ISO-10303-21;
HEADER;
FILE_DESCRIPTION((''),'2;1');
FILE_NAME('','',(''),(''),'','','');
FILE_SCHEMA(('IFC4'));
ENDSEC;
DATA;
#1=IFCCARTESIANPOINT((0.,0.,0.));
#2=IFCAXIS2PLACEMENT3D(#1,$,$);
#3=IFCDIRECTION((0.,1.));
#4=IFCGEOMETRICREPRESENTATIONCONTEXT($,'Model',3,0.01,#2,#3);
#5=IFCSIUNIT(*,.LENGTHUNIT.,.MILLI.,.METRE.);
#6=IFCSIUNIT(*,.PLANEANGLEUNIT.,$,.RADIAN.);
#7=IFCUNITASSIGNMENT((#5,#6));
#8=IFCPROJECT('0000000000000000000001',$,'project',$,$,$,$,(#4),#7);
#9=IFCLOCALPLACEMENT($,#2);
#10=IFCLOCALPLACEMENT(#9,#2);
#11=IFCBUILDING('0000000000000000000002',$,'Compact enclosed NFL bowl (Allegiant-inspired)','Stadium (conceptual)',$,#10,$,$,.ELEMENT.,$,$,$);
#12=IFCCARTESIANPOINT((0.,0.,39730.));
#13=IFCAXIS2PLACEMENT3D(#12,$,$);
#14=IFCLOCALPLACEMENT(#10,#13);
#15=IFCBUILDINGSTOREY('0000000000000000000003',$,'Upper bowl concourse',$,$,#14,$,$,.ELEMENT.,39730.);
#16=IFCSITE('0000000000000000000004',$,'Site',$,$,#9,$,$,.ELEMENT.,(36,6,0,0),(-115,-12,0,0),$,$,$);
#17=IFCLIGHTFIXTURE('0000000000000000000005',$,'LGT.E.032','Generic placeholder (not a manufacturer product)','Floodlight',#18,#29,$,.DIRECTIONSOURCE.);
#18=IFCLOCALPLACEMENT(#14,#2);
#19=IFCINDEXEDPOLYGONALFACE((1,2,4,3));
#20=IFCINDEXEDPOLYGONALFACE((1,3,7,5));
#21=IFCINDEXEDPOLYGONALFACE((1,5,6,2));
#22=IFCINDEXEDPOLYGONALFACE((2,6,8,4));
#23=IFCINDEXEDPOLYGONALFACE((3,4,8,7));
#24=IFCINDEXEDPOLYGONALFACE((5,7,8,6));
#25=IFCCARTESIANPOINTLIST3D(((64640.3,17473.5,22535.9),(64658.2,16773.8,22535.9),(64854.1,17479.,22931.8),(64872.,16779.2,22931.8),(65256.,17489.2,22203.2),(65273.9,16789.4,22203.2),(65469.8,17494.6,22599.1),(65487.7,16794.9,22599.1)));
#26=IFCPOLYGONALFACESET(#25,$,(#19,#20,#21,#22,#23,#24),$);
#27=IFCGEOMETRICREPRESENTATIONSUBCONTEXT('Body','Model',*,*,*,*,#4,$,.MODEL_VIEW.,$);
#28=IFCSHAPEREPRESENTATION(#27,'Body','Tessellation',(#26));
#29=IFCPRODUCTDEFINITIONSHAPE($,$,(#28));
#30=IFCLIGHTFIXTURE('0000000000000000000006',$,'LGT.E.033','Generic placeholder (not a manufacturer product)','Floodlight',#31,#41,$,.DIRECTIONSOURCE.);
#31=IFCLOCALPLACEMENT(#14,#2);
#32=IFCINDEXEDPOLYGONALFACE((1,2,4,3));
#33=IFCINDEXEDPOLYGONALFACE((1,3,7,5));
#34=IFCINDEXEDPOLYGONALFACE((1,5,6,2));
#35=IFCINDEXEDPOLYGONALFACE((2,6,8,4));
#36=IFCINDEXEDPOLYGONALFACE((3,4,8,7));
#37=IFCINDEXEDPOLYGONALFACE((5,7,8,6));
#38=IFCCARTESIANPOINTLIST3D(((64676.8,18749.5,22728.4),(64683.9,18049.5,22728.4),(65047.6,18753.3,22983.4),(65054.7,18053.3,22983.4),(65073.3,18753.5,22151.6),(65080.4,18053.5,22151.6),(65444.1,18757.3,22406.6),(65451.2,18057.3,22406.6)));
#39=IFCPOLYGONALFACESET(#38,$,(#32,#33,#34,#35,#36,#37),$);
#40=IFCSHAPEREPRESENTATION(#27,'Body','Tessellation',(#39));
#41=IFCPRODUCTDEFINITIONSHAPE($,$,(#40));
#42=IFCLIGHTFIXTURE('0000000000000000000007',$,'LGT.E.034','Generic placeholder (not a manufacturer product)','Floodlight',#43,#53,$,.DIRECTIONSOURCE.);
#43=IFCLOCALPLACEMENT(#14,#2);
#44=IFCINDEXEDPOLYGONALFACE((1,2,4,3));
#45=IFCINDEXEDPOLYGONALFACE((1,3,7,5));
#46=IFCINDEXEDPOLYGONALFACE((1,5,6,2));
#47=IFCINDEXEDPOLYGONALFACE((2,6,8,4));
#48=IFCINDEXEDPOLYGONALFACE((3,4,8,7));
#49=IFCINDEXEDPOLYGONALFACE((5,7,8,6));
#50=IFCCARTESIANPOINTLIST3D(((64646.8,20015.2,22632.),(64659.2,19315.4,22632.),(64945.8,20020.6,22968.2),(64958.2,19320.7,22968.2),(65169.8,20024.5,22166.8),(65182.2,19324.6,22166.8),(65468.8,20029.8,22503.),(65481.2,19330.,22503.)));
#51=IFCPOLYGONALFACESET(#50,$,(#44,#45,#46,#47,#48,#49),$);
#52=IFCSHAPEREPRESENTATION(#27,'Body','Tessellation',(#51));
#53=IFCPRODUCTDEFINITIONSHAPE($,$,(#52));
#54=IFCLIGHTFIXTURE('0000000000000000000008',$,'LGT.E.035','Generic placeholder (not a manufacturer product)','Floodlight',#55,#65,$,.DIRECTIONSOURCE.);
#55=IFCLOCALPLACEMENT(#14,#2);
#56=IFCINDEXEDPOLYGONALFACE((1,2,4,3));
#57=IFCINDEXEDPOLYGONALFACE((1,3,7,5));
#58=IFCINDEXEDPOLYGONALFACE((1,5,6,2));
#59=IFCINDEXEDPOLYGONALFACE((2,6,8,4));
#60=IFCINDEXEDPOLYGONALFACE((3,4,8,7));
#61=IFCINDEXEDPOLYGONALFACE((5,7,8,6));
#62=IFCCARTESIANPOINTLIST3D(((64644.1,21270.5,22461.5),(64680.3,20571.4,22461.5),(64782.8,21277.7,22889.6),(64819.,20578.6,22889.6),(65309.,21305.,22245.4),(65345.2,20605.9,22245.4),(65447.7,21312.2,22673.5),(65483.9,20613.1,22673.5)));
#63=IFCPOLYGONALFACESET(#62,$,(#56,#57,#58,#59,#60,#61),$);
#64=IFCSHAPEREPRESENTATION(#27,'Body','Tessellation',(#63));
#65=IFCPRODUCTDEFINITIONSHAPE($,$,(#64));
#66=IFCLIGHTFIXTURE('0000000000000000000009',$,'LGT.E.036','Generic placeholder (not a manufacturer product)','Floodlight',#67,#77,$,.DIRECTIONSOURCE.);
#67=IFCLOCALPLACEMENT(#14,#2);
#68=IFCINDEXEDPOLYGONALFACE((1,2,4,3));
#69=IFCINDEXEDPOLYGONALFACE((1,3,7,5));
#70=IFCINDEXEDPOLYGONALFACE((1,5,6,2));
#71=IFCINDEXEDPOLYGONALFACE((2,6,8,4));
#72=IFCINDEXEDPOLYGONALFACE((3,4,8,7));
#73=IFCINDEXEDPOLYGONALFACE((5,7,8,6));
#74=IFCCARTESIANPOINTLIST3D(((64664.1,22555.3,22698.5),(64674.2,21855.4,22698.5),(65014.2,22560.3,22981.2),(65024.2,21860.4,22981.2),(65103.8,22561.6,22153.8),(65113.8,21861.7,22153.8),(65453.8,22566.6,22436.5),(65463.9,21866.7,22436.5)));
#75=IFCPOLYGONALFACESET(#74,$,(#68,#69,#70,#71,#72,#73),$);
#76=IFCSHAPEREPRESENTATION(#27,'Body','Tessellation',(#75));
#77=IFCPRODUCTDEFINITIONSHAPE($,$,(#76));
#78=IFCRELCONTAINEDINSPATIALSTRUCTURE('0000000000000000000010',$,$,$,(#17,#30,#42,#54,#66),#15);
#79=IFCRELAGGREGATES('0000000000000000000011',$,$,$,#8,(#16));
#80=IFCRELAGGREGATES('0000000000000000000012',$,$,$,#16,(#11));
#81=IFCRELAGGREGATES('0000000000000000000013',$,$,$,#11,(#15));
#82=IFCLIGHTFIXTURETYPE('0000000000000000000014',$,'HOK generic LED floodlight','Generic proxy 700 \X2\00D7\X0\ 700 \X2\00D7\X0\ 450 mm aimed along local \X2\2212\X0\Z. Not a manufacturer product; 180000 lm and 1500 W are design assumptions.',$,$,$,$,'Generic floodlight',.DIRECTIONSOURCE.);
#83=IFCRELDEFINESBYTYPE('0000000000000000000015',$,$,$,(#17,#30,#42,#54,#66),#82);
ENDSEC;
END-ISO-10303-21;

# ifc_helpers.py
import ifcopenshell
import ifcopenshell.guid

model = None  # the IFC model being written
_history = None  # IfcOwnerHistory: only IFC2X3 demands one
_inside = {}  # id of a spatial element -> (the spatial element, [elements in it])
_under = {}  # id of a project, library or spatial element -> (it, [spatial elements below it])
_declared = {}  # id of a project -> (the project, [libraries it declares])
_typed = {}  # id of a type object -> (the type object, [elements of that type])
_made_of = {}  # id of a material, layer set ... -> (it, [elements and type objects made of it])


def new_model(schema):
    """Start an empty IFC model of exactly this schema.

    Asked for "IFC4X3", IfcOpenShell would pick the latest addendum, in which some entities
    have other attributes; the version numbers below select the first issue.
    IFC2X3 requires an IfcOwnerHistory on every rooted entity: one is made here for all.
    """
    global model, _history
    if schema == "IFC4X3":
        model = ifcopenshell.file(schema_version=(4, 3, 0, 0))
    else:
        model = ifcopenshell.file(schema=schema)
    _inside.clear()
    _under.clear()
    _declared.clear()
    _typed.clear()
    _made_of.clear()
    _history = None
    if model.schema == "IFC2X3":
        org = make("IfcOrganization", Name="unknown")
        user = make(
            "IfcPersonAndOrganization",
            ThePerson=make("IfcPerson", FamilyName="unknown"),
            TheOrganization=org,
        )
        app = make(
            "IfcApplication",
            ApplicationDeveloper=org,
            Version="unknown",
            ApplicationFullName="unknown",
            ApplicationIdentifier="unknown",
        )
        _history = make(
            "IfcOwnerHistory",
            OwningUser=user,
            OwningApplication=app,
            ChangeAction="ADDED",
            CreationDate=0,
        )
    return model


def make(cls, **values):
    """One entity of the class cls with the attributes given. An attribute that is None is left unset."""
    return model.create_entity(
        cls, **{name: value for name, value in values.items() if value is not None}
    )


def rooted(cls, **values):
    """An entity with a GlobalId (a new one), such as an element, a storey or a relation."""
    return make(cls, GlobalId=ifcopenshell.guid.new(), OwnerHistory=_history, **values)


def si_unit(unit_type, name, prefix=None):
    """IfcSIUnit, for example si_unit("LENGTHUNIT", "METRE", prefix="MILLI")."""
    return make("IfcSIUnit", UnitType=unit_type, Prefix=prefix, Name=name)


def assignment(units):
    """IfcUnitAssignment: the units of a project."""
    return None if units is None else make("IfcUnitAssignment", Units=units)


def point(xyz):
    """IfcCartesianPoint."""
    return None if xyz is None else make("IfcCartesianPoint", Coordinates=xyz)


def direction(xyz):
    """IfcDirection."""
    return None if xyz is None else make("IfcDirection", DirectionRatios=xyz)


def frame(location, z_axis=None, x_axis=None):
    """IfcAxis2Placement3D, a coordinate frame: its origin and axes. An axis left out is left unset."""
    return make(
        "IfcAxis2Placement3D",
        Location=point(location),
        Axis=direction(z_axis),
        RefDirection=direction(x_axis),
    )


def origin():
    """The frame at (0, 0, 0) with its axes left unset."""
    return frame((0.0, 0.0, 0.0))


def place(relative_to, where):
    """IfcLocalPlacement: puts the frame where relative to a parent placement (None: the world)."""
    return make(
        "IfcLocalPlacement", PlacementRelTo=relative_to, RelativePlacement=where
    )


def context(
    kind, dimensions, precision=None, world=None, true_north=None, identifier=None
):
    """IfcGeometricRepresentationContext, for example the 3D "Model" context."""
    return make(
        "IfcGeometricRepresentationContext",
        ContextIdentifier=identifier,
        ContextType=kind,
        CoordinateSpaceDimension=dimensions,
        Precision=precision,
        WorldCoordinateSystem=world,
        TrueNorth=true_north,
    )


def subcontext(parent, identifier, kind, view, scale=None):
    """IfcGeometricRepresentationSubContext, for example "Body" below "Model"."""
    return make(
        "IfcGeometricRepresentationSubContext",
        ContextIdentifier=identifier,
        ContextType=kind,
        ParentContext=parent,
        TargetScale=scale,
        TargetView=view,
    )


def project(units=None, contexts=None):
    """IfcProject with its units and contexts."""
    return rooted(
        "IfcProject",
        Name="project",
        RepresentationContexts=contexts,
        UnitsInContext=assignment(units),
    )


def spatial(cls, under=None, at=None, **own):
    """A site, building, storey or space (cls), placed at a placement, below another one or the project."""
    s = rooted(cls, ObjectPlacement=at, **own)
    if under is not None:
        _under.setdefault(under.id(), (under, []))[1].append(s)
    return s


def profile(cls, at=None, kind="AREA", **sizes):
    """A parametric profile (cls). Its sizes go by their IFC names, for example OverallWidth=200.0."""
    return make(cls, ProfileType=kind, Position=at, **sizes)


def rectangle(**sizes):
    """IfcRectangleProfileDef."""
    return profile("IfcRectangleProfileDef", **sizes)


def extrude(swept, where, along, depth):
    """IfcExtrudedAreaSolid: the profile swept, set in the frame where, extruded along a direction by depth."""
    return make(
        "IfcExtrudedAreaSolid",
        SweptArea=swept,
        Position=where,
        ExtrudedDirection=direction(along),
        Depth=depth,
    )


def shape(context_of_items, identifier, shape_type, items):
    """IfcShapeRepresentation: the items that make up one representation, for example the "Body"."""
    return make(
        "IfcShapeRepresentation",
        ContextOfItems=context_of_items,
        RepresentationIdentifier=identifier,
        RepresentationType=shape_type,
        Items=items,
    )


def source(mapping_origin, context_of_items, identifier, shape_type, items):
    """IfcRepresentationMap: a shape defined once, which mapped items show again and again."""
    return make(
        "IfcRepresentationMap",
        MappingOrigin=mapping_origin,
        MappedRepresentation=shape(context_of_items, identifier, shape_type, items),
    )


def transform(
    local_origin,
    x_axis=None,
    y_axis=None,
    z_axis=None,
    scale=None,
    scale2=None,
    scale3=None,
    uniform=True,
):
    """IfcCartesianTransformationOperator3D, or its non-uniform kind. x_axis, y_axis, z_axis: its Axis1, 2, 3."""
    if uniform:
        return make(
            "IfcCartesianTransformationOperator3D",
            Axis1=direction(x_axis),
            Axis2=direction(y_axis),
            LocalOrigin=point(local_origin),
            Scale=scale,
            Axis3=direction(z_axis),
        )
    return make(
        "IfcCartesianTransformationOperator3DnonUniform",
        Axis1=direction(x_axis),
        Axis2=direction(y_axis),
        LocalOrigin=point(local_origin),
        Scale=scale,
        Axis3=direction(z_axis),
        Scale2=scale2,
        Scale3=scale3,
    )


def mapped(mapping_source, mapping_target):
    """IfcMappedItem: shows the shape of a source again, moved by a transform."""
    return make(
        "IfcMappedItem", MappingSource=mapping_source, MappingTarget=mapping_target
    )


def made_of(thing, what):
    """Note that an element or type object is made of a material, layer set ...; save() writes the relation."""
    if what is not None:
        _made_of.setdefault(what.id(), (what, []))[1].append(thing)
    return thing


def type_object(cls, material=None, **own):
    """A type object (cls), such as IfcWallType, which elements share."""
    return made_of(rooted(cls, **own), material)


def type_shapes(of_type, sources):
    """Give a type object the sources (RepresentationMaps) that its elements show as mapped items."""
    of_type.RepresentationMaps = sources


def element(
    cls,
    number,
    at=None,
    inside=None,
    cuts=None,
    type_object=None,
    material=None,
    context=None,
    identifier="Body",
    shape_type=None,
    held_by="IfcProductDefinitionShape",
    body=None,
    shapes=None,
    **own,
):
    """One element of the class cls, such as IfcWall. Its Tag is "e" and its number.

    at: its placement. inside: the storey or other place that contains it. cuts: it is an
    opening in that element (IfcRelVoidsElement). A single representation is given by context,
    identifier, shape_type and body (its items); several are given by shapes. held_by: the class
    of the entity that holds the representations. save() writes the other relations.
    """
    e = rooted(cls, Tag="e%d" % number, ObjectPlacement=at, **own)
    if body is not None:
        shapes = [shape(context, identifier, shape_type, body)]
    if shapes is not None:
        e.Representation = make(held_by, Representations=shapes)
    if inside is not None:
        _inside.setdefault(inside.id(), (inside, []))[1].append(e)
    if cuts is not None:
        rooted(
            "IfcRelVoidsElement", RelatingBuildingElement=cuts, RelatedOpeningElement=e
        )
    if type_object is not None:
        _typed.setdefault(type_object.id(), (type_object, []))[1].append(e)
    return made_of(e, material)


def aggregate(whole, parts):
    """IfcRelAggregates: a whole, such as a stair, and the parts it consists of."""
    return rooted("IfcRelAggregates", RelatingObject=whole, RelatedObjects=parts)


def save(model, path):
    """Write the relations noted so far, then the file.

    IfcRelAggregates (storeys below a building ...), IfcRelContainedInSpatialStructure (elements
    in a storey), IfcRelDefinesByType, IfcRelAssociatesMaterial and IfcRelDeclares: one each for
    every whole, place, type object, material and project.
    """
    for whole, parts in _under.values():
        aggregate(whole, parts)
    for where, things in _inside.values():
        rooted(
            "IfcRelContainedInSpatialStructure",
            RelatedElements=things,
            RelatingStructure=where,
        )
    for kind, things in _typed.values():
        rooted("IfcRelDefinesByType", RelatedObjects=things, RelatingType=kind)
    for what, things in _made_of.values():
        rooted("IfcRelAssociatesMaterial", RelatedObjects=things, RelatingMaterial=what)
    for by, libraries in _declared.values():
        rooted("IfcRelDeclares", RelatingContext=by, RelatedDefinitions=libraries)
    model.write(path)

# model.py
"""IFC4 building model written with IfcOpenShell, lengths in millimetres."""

from ifc_helpers import new_model, si_unit, direction, frame, origin, place, context, subcontext, project, spatial, rectangle, extrude, source, transform, mapped, type_object, type_shapes, element, save


model = new_model("IFC4")

# Units and contexts
model_context = context("Model", 3, precision=0.01, world=origin(), true_north=direction((0.0, 1.0)))
body_context = subcontext(model_context, "Body", "Model", "MODEL_VIEW")
ifc_project = project(units=[si_unit("LENGTHUNIT", "METRE", prefix="MILLI"), si_unit("PLANEANGLEUNIT", "RADIAN")], contexts=[model_context])

# Site, building, storey
site_placement = place(None, origin())
site = spatial("IfcSite", under=ifc_project, at=site_placement, Name="Site", CompositionType="ELEMENT", RefLatitude=(36, 6, 0, 0), RefLongitude=(-115, -12, 0, 0))
building_placement = place(site_placement, origin())
building = spatial("IfcBuilding", under=site, at=building_placement, Name="Compact enclosed NFL bowl (Allegiant-inspired)", Description="Stadium (conceptual)", CompositionType="ELEMENT")
storey_placement = place(building_placement, frame((0.0, 0.0, 39730.0)))
storey = spatial("IfcBuildingStorey", under=building, at=storey_placement, Name="Upper bowl concourse", CompositionType="ELEMENT", Elevation=39730.0)

# Light fixtures
light_fixture_type = type_object("IfcLightFixtureType", Name="HOK generic LED floodlight", Description="Generic proxy 700 × 700 × 450 mm aimed along local −Z. Not a manufacturer product; 180000 lm and 1500 W are design assumptions.", ElementType="Generic floodlight", PredefinedType="DIRECTIONSOURCE")
shared_shape = source(origin(), body_context, "Body", "SweptSolid", [
    extrude(rectangle(XDim=700.0, YDim=700.0), frame((0.0, 0.0, -225.0)), (0.0, 0.0, 1.0), 450.0),
])
type_shapes(light_fixture_type, [shared_shape])
for number, where, z_axis, x_axis, name in (
    (1, (65064.0, 17134.2, 22567.5), (0.47509, 0.0121, 0.879854), (-0.02546, 0.999676, 0.0), "LGT.E.032"),
    (2, (65064.0, 18403.4, 22567.5), (0.823981, 0.008368, 0.566555), (-0.010155, 0.999948, 0.0), "LGT.E.033"),
    (3, (65064.0, 19672.6, 22567.5), (0.664463, 0.011798, 0.747228), (-0.017753, 0.999842, 0.0), "LGT.E.034"),
    (4, (65064.0, 20941.8, 22567.5), (0.308275, 0.015987, 0.951163), (-0.05179, 0.998658, 0.0), "LGT.E.035"),
    (5, (65064.0, 22211.0, 22567.5), (0.777995, 0.011198, 0.628171), (-0.014392, 0.999896, 0.0), "LGT.E.036"),
):
    element("IfcLightFixture", number, at=place(storey_placement, frame(where, z_axis=z_axis, x_axis=x_axis)), inside=storey, type_object=light_fixture_type, Name=name, Description="Generic placeholder (not a manufacturer product)", ObjectType="Floodlight", PredefinedType="DIRECTIONSOURCE", context=body_context, shape_type="MappedRepresentation", body=[
        mapped(shared_shape, transform((0.0, 0.0, 0.0))),
    ])

save(model, "model.ifc")
